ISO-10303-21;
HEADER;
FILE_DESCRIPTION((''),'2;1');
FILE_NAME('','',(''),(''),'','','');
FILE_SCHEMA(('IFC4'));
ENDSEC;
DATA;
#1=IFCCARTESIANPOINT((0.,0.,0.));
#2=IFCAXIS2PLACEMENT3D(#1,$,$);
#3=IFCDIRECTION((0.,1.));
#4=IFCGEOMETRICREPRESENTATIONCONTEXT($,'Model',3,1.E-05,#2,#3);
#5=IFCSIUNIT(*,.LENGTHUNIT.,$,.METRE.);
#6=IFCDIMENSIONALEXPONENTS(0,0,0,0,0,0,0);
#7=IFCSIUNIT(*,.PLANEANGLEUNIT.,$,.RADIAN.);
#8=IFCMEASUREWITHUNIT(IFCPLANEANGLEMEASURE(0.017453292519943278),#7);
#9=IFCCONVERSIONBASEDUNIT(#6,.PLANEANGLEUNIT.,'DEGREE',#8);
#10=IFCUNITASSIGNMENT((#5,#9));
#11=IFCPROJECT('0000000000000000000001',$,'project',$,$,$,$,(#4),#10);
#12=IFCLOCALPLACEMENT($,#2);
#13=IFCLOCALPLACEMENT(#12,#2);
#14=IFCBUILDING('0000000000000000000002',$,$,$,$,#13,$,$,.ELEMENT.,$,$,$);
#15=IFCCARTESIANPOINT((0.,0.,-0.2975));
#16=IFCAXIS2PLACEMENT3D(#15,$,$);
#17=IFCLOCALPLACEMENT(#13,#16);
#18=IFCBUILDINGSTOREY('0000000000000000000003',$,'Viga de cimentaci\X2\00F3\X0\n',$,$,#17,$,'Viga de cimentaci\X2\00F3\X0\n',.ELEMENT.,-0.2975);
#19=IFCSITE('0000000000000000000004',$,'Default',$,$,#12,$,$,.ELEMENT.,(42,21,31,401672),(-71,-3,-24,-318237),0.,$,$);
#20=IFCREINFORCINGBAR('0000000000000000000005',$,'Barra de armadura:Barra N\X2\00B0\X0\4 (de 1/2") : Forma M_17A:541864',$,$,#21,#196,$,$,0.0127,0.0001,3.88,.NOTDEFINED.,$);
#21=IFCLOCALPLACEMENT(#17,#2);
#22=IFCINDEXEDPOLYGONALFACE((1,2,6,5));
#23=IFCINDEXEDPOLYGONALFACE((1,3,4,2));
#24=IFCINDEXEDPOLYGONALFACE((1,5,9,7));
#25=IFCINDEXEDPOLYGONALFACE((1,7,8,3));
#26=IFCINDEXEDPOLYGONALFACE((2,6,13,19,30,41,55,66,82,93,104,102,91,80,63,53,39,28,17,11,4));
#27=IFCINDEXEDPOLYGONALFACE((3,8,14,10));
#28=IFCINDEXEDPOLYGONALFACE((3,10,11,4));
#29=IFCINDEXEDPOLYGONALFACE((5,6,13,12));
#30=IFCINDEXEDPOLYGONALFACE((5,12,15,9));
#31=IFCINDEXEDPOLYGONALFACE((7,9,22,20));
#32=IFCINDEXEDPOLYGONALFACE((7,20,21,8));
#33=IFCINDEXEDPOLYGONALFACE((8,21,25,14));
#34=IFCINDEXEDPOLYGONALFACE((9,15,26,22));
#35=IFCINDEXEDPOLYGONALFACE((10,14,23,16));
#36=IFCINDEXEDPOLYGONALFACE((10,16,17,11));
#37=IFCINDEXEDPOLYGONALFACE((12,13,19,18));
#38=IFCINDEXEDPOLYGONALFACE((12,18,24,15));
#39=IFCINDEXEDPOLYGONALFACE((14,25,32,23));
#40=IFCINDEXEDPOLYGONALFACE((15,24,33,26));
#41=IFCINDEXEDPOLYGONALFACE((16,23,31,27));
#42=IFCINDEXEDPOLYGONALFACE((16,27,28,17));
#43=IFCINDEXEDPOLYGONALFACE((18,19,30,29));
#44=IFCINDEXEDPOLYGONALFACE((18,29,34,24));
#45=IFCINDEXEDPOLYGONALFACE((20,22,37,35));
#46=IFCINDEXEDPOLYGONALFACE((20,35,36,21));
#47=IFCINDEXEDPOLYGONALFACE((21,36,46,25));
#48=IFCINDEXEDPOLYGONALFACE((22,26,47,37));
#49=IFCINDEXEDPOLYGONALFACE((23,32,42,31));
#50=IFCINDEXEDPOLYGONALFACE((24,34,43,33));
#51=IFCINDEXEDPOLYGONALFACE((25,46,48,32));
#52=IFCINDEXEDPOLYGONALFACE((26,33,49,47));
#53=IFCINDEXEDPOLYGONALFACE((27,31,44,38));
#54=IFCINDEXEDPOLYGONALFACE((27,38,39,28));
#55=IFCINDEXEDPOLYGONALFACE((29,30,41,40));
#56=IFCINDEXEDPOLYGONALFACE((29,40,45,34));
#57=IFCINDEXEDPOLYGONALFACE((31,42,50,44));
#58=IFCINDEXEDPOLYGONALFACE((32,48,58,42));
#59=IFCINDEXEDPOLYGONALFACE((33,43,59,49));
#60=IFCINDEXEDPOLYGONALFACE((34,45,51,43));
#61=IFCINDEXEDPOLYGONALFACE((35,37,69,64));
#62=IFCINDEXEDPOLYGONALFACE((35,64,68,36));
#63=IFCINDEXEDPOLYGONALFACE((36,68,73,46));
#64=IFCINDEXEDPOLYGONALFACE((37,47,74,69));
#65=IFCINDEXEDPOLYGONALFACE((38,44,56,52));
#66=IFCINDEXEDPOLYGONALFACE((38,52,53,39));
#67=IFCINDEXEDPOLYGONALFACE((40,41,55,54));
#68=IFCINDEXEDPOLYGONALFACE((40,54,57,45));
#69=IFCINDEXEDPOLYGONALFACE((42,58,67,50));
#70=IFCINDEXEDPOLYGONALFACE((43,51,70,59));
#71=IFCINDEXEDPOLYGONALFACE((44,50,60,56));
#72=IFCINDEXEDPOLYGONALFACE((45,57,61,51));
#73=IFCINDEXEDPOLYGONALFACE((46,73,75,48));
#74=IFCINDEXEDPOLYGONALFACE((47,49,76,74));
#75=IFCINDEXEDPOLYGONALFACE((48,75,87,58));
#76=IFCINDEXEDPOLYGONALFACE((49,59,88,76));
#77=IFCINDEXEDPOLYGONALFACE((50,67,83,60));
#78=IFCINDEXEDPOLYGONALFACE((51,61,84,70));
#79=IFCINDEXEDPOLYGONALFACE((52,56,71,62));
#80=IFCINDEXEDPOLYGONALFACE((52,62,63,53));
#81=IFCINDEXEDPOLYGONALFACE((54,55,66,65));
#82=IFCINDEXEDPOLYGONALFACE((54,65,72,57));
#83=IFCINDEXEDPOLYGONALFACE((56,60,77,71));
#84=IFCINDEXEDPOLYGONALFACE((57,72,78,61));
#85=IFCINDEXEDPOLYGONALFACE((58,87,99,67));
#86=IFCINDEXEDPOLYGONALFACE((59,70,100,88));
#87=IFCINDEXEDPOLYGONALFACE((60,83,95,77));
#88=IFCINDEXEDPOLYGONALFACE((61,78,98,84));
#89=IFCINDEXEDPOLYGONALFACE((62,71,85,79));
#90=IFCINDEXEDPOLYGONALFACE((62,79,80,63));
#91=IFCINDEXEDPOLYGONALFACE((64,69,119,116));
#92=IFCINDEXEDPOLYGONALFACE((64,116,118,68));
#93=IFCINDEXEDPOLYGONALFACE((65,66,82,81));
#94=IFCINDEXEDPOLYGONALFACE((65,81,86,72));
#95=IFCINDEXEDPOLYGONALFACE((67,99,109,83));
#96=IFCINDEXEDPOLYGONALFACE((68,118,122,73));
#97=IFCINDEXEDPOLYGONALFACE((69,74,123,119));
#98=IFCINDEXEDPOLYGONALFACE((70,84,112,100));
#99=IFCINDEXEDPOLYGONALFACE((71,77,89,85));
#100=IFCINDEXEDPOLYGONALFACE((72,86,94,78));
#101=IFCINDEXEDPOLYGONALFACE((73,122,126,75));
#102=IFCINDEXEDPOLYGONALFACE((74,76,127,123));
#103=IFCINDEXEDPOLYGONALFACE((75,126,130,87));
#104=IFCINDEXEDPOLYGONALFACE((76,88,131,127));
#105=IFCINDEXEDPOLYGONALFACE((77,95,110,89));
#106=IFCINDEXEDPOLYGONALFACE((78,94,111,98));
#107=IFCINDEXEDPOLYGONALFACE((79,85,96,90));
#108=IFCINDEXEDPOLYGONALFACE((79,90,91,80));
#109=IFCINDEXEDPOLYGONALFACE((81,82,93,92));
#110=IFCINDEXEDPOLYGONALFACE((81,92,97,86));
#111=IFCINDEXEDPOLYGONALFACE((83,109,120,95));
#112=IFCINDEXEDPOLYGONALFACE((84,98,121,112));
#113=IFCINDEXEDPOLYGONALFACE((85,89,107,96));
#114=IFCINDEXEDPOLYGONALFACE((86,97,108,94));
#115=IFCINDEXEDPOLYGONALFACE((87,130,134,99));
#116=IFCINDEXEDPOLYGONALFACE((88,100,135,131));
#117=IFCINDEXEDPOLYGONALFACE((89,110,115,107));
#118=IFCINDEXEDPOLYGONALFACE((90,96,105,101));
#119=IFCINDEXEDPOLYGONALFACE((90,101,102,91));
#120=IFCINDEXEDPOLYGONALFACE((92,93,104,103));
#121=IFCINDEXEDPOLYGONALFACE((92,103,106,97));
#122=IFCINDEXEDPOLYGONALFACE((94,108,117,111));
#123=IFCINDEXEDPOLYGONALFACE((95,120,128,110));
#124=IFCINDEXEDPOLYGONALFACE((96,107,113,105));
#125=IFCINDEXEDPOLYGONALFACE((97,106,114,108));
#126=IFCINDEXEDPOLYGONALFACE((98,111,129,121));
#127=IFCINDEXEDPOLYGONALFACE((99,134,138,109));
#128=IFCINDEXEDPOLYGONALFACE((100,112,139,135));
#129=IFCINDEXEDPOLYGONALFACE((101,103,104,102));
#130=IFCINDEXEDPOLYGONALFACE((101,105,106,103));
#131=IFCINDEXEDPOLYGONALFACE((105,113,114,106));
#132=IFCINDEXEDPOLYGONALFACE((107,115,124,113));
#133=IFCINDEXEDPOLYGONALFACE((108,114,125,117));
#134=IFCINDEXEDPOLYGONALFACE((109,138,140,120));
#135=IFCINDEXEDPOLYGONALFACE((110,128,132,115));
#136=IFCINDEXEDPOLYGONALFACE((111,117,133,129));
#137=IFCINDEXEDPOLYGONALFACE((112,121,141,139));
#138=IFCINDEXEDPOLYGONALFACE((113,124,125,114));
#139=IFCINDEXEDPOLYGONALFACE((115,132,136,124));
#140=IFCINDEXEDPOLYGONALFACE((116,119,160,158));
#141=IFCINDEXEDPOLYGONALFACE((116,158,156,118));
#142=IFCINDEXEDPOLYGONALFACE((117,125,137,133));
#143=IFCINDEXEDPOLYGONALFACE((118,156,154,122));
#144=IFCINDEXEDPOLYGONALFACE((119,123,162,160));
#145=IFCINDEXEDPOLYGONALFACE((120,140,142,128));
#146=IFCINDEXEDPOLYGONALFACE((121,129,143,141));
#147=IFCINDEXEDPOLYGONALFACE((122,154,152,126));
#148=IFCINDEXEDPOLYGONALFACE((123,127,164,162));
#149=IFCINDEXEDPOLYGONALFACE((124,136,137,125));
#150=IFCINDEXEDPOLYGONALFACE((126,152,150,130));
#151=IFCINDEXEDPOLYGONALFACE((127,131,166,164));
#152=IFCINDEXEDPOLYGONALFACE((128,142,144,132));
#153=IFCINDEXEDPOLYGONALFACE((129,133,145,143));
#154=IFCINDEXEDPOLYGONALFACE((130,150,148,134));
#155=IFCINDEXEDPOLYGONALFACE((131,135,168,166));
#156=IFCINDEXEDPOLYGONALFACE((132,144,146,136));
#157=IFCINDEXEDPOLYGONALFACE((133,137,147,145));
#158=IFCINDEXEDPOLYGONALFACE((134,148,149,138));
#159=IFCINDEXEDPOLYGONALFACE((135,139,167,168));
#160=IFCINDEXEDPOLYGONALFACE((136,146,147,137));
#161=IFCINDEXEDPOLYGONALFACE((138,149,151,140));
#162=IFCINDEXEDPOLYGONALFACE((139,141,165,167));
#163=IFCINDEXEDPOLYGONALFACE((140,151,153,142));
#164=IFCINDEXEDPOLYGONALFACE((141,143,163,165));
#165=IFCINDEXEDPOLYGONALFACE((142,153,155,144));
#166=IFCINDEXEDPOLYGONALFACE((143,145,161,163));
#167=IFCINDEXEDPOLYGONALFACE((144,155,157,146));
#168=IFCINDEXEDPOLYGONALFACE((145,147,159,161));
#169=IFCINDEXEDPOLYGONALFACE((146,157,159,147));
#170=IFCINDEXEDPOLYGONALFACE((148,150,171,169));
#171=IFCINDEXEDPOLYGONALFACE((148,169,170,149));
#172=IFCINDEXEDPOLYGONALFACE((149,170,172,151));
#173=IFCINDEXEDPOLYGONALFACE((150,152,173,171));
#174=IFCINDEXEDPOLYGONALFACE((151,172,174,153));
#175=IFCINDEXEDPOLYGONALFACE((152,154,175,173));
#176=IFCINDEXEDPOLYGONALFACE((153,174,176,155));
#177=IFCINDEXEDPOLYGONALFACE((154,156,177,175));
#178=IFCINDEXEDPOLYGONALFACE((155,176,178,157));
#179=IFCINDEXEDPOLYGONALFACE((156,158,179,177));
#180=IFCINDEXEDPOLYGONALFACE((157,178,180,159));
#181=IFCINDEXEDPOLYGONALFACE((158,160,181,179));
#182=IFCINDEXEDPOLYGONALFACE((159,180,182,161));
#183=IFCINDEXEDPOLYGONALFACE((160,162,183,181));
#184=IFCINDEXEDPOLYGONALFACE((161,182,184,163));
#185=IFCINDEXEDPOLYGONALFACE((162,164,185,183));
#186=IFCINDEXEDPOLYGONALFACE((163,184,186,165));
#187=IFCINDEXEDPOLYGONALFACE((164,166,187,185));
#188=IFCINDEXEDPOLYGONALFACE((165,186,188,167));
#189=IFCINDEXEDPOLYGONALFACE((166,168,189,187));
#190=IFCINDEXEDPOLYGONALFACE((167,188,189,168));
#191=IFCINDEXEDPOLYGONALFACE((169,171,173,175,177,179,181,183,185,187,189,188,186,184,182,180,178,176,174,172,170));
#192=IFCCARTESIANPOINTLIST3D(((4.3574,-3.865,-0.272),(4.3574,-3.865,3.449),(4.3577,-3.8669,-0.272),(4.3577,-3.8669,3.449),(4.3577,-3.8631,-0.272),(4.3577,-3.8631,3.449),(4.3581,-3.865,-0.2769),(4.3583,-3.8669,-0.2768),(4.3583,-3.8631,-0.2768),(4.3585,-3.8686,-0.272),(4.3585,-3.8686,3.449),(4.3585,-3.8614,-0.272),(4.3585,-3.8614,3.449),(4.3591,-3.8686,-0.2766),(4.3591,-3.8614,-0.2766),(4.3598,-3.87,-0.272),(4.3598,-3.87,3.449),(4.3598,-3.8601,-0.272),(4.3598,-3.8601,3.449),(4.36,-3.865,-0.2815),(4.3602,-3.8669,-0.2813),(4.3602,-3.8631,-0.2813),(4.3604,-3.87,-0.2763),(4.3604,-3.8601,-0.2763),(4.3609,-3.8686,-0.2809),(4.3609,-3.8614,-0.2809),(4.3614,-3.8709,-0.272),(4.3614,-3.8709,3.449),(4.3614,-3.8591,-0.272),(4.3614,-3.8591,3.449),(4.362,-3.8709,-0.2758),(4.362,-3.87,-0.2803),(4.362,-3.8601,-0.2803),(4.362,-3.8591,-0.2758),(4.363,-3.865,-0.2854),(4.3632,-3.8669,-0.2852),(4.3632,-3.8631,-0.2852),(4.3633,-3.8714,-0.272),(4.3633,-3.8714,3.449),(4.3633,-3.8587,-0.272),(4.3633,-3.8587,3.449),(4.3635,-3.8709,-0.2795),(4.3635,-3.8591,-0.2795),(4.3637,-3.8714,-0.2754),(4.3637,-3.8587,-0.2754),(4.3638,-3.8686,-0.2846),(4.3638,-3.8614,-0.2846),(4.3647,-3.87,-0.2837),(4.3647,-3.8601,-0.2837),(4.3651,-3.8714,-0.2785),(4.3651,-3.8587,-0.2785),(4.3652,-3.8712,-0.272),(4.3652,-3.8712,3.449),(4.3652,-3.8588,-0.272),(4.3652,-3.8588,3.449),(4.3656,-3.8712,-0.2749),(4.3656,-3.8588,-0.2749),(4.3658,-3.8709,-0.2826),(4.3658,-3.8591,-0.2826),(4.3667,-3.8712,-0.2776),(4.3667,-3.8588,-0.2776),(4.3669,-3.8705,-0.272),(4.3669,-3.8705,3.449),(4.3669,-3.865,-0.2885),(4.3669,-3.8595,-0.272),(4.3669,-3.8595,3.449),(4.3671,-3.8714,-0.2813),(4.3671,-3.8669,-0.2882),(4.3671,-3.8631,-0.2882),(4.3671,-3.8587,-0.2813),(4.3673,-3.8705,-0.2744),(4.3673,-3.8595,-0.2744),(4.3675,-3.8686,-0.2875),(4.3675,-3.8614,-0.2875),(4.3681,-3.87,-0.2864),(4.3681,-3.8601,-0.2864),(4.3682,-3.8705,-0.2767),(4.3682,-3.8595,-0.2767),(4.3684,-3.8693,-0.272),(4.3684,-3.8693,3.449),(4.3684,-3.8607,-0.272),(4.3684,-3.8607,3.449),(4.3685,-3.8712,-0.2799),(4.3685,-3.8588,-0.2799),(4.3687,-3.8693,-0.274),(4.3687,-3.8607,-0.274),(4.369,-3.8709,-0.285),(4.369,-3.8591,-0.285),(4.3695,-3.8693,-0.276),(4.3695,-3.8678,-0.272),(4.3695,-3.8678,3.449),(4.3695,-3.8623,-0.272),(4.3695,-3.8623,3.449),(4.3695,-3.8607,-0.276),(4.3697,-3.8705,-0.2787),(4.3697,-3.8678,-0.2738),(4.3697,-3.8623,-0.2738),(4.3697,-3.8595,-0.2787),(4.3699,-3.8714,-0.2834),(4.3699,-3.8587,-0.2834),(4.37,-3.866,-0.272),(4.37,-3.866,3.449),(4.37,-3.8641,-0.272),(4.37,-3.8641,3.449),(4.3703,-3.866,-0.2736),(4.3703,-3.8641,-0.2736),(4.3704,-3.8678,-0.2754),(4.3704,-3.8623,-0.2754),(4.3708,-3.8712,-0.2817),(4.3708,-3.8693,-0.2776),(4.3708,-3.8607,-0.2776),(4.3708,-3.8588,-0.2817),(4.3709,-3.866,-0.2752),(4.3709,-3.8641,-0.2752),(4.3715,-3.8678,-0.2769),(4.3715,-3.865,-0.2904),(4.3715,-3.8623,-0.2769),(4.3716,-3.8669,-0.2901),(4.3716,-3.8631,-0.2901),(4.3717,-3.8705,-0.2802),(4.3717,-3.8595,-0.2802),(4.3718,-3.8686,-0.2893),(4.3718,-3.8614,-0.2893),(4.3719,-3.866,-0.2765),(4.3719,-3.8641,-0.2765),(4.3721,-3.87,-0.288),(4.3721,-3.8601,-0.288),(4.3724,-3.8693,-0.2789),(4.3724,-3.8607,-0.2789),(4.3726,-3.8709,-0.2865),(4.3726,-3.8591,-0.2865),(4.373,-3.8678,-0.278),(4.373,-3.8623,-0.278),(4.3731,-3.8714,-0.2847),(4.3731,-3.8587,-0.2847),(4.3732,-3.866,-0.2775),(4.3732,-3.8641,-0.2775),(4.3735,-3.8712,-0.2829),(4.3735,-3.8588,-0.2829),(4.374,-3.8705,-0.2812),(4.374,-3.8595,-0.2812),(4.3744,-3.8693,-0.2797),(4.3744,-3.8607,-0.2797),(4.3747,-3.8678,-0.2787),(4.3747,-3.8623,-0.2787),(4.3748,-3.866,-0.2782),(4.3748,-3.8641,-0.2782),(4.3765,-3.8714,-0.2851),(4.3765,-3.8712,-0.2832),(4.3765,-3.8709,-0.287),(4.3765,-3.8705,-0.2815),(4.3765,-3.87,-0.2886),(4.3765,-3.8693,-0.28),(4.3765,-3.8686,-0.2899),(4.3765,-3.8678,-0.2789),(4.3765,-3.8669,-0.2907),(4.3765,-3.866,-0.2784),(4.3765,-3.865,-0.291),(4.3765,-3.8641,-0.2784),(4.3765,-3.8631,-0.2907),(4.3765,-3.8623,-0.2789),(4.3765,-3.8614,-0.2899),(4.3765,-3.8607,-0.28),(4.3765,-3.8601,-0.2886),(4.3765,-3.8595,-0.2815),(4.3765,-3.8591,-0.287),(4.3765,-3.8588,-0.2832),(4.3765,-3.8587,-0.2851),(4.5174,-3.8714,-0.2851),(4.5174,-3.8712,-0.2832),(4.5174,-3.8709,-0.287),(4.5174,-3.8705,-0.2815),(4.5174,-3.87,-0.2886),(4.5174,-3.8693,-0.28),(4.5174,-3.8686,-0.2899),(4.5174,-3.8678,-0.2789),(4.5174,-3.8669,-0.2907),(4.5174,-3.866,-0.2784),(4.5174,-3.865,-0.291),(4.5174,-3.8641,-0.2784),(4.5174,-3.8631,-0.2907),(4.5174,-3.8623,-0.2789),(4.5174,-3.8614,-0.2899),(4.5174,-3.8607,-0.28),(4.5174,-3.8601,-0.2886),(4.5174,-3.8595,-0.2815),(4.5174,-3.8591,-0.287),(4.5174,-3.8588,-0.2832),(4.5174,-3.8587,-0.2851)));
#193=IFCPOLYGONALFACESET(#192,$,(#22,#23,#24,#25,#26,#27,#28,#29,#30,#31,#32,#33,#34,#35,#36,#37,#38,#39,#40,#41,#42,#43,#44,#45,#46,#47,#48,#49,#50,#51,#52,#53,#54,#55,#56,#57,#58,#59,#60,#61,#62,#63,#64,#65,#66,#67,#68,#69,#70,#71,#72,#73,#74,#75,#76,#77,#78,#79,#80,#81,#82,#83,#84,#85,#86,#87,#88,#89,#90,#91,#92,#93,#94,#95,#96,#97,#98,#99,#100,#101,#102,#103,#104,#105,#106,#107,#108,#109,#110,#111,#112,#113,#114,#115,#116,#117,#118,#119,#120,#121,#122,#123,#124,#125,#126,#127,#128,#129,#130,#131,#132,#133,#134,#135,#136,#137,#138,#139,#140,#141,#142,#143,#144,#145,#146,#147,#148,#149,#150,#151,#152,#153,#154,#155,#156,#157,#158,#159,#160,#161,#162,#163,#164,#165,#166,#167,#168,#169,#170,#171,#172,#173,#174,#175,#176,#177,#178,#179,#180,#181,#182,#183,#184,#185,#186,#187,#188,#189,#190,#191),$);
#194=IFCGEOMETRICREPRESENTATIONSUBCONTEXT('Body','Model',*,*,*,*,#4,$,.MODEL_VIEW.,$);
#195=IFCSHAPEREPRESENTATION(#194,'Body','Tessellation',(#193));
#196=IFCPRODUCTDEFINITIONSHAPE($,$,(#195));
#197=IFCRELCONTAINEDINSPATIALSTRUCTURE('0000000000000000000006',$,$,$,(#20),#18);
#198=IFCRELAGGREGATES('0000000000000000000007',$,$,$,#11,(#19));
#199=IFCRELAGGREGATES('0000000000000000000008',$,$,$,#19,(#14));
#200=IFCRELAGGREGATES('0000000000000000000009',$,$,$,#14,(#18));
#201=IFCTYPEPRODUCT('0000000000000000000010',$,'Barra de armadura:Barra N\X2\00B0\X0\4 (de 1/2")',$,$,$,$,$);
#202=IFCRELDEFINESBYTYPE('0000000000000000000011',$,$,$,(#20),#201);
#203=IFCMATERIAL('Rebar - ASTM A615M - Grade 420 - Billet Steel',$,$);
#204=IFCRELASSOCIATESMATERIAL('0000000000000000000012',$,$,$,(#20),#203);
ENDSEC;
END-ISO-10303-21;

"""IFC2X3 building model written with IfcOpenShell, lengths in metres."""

from ifc_helpers import new_model, entity, si_unit, converted_unit, direction, frame, origin, place, context, subcontext, project, spatial, material, type_object, element, save


model = new_model("IFC2X3")

# Units and contexts
model_context = context("Model", 3, precision=1e-05, world=origin(), true_north=direction((0.0, 1.0)))
body_context = subcontext(model_context, "Body", "Model", "MODEL_VIEW")
ifc_project = project(units=[si_unit("LENGTHUNIT", "METRE"), converted_unit("PLANEANGLEUNIT", "DEGREE", entity("IfcPlaneAngleMeasure", 0.017453292519943278), si_unit("PLANEANGLEUNIT", "RADIAN"), dimensions=[0, 0, 0, 0, 0, 0, 0])], contexts=[model_context])

# Site, building, storey
site_placement = place(None, origin())
site = spatial("IfcSite", under=ifc_project, at=site_placement, Name="Default", CompositionType="ELEMENT", RefLatitude=(42, 21, 31, 401672), RefLongitude=(-71, -3, -24, -318237), RefElevation=0.0)
building_placement = place(site_placement, origin())
building = spatial("IfcBuilding", under=site, at=building_placement, CompositionType="ELEMENT")
storey_placement = place(building_placement, frame((0.0, 0.0, -0.2975)))
storey = spatial("IfcBuildingStorey", under=building, at=storey_placement, Name="Viga de cimentación", LongName="Viga de cimentación", CompositionType="ELEMENT", Elevation=-0.2975)

# Reinforcing bar
ifc_material_1 = material(Name="Rebar - ASTM A615M - Grade 420 - Billet Steel")
type_product_1 = type_object("IfcTypeProduct", Name="Barra de armadura:Barra N°4 (de 1/2\")")
reinforcing_bar_1_placement = place(storey_placement, origin())
element("IfcReinforcingBar", 1, at=reinforcing_bar_1_placement, inside=storey, type_object=type_product_1, material=ifc_material_1, Name="Barra de armadura:Barra N°4 (de 1/2\") : Forma M_17A:541864", BarLength=3.88, BarRole="NOTDEFINED", CrossSectionArea=0.0001, NominalDiameter=0.0127, context=body_context, shape_type="AdvancedSweptSolid", body=[
    entity("IfcSweptDiskSolid", entity("IfcCompositeCurve", [entity("IfcCompositeCurveSegment", "CONTINUOUS", True, entity("IfcPolyline", [entity("IfcCartesianPoint", [4.3638, -3.865, 3.449]), entity("IfcCartesianPoint", [4.3638, -3.865, -0.272])])), entity("IfcCompositeCurveSegment", "CONTINUOUS", True, entity("IfcTrimmedCurve", entity("IfcCircle", entity("IfcAxis2Placement3D", entity("IfcCartesianPoint", [4.3765, -3.865, -0.272]), entity("IfcDirection", [0.0, -1.0, 0.0]), entity("IfcDirection", [0.0, 0.0, -1.0])), 0.0127), [entity("IfcParameterValue", 270.0)], [entity("IfcParameterValue", 360.0)], True, "PARAMETER")), entity("IfcCompositeCurveSegment", "CONTINUOUS", True, entity("IfcPolyline", [entity("IfcCartesianPoint", [4.3765, -3.865, -0.2847]), entity("IfcCartesianPoint", [4.5174, -3.865, -0.2847])]))], False), 0.0063, None, 0.0, 92.0),
])

save(model, "model.ifc")
